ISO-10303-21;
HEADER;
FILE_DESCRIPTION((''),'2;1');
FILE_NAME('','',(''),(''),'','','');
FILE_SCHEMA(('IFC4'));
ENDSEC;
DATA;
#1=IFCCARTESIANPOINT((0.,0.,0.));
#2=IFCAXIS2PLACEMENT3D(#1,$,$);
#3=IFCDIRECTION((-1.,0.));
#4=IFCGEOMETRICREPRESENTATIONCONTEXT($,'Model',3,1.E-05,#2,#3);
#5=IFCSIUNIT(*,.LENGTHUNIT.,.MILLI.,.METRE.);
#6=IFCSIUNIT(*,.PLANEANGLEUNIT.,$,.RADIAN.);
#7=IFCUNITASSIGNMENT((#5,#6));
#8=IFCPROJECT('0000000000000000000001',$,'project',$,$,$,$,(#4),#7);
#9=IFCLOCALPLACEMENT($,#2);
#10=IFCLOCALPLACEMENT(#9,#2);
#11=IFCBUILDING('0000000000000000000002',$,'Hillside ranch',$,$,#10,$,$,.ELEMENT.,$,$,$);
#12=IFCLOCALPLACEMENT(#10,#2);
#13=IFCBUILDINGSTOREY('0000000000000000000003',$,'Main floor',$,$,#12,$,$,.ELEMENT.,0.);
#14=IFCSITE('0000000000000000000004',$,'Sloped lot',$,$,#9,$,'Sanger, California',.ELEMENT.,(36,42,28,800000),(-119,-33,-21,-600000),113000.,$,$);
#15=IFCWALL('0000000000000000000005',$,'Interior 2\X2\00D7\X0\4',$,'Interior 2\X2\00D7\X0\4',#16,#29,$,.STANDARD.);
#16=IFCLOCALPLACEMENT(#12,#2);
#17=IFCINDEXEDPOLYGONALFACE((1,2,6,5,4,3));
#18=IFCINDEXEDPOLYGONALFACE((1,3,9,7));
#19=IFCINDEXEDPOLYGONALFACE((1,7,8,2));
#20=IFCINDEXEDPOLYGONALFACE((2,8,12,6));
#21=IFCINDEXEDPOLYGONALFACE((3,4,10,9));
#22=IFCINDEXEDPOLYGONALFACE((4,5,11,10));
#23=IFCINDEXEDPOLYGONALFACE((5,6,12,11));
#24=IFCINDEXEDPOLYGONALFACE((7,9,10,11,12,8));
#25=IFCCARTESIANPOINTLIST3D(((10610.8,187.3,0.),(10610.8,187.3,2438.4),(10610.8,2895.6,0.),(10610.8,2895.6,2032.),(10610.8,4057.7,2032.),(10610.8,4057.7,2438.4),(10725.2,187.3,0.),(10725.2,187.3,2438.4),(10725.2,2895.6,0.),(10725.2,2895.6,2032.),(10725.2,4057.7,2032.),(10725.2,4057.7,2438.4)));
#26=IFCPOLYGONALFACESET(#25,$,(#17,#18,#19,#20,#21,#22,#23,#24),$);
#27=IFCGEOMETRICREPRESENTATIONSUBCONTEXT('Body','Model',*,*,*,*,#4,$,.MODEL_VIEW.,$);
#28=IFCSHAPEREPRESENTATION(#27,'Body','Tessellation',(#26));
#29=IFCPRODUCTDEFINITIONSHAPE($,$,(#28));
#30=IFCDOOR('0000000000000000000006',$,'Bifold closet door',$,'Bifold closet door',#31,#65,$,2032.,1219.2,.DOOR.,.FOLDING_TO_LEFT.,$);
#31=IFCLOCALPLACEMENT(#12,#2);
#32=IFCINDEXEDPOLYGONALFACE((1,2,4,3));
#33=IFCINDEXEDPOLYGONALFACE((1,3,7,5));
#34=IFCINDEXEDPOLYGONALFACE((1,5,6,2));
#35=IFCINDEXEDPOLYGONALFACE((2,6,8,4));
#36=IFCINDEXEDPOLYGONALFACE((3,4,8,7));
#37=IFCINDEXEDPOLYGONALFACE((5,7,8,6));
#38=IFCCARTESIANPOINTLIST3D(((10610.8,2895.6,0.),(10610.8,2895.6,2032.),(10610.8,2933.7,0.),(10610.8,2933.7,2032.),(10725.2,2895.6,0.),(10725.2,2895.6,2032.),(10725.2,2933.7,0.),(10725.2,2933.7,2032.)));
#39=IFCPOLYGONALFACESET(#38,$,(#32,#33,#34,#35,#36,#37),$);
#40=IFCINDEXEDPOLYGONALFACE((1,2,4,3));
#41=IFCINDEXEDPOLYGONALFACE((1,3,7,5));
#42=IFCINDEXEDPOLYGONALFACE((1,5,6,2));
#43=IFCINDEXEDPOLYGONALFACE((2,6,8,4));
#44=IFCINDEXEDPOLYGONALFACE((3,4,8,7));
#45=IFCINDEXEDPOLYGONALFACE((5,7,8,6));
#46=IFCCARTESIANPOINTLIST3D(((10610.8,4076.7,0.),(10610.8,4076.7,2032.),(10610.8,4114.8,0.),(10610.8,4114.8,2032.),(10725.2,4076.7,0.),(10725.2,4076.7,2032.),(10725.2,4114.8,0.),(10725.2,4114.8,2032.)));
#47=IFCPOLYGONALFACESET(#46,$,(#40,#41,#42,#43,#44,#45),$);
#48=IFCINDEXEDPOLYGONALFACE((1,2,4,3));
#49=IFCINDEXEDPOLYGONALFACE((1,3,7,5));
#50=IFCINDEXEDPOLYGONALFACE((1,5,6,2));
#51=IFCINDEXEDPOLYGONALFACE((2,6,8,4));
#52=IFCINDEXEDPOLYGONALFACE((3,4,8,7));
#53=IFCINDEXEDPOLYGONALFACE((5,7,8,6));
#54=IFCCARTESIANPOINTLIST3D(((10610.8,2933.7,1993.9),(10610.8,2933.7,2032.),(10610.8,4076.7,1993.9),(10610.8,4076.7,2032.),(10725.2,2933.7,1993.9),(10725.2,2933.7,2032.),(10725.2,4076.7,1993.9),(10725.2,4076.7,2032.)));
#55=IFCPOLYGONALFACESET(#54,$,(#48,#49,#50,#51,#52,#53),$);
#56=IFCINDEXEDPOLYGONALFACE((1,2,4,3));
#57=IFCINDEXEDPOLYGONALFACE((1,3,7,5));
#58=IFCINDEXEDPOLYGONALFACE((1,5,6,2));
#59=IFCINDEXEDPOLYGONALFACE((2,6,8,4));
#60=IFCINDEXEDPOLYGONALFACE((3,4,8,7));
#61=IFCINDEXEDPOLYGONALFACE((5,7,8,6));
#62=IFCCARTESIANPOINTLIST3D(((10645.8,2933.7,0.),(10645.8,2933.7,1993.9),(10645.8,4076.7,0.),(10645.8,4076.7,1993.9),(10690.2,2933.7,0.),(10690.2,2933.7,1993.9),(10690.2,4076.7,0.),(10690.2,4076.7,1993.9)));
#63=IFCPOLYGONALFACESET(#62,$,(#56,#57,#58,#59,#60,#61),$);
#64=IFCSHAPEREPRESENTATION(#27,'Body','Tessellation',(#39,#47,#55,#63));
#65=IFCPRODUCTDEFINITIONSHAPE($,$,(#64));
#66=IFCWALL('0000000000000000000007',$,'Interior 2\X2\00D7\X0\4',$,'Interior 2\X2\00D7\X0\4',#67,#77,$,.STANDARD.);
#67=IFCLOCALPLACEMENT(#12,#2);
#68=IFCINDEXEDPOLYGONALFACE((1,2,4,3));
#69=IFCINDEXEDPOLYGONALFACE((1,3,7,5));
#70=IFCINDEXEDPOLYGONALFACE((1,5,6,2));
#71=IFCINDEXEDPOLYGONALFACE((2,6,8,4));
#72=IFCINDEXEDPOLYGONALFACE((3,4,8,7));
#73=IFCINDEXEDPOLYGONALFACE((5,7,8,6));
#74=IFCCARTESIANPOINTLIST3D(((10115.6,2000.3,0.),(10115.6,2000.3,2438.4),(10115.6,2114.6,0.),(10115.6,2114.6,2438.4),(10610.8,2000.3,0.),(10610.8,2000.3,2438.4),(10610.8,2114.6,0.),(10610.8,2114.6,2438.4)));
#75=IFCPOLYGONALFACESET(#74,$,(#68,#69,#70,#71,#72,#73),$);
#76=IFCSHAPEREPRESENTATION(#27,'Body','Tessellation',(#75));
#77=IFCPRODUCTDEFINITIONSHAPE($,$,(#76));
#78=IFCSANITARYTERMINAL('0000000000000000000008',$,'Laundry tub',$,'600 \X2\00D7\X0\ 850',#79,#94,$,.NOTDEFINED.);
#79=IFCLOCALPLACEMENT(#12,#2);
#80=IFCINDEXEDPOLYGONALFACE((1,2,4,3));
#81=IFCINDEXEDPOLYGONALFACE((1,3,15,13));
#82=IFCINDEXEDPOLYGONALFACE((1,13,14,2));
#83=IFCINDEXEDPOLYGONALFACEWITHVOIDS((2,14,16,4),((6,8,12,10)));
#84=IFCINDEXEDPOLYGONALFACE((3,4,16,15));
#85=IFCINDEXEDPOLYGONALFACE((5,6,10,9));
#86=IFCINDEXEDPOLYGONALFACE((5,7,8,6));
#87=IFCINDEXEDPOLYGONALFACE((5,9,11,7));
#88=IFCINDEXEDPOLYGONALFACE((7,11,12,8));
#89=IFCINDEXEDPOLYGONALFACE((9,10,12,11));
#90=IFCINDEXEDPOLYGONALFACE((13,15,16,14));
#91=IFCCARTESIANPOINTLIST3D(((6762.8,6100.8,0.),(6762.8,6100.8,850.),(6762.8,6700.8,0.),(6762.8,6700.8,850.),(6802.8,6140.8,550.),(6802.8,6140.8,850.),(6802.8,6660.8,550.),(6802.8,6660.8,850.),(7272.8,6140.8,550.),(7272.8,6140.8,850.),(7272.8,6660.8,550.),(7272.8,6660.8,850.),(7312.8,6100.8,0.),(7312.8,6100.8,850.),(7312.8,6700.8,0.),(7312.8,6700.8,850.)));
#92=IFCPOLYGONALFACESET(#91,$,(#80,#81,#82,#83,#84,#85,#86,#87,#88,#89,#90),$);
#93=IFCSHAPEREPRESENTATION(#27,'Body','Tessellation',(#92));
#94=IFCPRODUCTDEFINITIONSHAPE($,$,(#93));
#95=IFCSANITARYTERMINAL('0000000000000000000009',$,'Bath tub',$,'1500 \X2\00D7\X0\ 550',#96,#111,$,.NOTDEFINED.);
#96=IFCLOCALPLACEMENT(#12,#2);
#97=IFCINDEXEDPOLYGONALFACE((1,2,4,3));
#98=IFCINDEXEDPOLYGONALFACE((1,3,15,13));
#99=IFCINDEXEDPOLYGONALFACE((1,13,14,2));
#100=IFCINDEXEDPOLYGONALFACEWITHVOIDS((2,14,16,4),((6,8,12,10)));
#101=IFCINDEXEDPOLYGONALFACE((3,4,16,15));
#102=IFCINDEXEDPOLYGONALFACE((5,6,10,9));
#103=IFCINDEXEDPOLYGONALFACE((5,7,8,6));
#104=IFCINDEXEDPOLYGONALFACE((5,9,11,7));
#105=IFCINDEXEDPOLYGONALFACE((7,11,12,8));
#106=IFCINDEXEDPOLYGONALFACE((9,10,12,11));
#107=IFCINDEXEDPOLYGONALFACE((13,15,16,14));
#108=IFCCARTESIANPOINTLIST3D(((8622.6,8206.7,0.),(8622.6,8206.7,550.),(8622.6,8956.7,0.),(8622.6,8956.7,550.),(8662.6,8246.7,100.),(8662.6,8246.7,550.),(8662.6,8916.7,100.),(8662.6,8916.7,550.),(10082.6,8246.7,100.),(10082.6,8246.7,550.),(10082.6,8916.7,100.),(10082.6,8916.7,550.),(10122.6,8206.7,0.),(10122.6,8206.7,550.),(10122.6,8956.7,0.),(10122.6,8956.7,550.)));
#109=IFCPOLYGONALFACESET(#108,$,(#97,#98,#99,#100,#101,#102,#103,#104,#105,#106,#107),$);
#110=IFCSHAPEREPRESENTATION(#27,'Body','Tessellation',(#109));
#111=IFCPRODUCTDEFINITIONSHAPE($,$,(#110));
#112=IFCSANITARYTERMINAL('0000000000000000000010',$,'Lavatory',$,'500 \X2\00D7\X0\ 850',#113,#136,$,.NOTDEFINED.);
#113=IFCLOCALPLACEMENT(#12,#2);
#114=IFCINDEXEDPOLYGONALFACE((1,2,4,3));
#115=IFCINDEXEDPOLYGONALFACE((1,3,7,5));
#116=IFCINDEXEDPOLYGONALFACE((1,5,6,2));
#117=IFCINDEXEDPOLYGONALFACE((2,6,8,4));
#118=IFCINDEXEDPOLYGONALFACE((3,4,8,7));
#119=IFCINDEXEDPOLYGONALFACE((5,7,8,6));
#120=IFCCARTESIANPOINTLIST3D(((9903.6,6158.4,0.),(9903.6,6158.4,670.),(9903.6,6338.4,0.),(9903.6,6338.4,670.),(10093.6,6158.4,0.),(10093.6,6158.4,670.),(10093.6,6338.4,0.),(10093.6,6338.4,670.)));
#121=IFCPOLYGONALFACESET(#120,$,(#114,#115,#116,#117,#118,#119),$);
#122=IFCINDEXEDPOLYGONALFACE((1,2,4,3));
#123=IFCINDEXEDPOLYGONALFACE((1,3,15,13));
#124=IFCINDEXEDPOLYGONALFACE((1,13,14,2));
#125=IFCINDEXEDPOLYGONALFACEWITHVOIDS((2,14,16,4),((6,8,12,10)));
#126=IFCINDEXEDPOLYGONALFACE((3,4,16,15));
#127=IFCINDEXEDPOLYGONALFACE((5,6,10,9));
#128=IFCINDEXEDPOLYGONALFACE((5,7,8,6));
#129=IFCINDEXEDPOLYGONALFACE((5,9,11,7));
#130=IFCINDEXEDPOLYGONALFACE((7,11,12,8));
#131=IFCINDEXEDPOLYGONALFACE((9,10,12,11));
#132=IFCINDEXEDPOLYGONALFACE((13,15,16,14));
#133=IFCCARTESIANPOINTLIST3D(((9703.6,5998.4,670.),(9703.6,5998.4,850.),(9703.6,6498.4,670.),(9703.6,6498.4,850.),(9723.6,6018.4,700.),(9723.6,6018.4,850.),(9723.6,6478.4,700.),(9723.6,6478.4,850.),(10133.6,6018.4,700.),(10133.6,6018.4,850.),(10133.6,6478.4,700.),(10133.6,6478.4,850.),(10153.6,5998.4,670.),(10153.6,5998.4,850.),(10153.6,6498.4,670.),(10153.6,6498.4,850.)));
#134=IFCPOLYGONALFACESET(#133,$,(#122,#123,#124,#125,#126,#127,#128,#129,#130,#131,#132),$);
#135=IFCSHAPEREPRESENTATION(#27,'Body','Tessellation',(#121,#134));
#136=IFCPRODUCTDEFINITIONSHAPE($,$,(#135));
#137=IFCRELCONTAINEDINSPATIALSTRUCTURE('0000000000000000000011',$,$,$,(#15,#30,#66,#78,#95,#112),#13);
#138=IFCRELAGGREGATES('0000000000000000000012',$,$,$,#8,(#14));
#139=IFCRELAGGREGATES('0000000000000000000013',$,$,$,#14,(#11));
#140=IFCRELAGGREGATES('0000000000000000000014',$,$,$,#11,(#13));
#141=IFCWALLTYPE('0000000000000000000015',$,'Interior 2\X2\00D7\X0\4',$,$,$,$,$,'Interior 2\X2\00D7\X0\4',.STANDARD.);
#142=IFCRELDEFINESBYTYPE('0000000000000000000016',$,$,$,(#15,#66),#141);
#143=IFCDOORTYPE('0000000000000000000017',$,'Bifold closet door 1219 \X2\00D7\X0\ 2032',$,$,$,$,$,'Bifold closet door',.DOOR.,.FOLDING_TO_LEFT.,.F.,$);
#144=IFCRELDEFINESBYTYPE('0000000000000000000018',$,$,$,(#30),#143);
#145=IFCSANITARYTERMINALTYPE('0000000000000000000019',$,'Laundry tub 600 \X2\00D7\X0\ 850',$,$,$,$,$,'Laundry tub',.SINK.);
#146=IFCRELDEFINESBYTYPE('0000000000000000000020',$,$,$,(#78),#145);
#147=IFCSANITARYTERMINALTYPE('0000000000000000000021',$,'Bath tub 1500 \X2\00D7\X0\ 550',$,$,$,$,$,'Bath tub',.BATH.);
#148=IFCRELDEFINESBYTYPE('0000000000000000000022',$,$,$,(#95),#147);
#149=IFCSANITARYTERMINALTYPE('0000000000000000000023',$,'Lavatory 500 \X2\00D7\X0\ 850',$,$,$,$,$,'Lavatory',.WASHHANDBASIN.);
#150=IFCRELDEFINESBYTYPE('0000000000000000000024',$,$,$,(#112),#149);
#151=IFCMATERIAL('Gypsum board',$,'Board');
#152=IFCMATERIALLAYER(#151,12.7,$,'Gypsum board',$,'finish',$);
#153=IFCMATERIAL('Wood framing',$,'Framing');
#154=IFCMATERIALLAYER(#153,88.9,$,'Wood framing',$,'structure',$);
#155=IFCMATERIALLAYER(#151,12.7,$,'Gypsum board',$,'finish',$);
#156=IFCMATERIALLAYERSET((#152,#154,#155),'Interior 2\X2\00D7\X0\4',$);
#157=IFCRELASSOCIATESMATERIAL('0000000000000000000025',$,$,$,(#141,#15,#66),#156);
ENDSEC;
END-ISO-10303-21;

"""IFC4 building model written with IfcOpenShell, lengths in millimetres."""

from ifc_helpers import new_model, entity, si_unit, direction, frame, origin, origin_with_axes, place, context, subcontext, project, spatial, polyline, outline, extrude, source, transform, mapped, material, layer, layer_set, layer_usage, type_object, type_shapes, element, fill, save


model = new_model("IFC4")

# Units and contexts
model_context = context("Model", 3, precision=1e-05, world=origin(), true_north=direction((-1.0, 0.0)))
body_context = subcontext(model_context, "Body", "Model", "MODEL_VIEW")
ifc_project = project(units=[si_unit("LENGTHUNIT", "METRE", prefix="MILLI"), si_unit("PLANEANGLEUNIT", "RADIAN")], contexts=[model_context])

# Site, building, storey
site_placement = place(None, origin())
site = spatial("IfcSite", under=ifc_project, at=site_placement, Name="Sloped lot", LongName="Sanger, California", CompositionType="ELEMENT", RefLatitude=(36, 42, 28, 800000), RefLongitude=(-119, -33, -21, -600000), RefElevation=113000.0)
building_placement = place(site_placement, origin())
building = spatial("IfcBuilding", under=site, at=building_placement, Name="Hillside ranch", CompositionType="ELEMENT")
storey_placement = place(building_placement, origin())
storey = spatial("IfcBuildingStorey", under=building, at=storey_placement, Name="Main floor", CompositionType="ELEMENT", Elevation=0.0)

# Shared definitions
ifc_material_1 = material(Name="Gypsum board", Category="Board")
ifc_layer_1 = layer(ifc_material_1, 12.7, Name="Gypsum board", Category="finish")
ifc_material_2 = material(Name="Wood framing", Category="Framing")
ifc_layer_2 = layer(ifc_material_2, 88.9, Name="Wood framing", Category="structure")
ifc_layer_3 = layer(ifc_material_1, 12.7, Name="Gypsum board", Category="finish")
ifc_layer_set = layer_set([ifc_layer_1, ifc_layer_2, ifc_layer_3], Name="Interior 2×4")
wall_type = type_object("IfcWallType", Name="Interior 2×4", ElementType="Interior 2×4", PredefinedType="STANDARD", material=ifc_layer_set)

# Wall, opening, door
door_type_1 = type_object("IfcDoorType", Name="Bifold closet door 1219 × 2032", ElementType="Bifold closet door", OperationType="FOLDING_TO_LEFT", ParameterTakesPrecedence=False, PredefinedType="DOOR")
ifc_layer_usage_1 = layer_usage(ifc_layer_set, "AXIS2", "NEGATIVE", 57.1)
wall_1_placement = place(storey_placement, frame((10668.0, 93.7, 0.0), z_axis=(0.0, 0.0, 1.0), x_axis=(0.0, 1.0, 0.0)))
wall_1 = element("IfcWall", 1, at=wall_1_placement, inside=storey, type_object=wall_type, material=ifc_layer_usage_1, Name="Interior 2×4", ObjectType="Interior 2×4", PredefinedType="STANDARD", context=body_context, shape_type="SweptSolid", body=[
    extrude(outline(polyline([(93.7, -57.1), (3964.0, -57.1), (3964.0, 57.1), (93.7, 57.1), (93.7, -57.1)])), origin(), (0.0, 0.0, 1.0), 2438.4),
])
opening_1_placement = place(wall_1_placement, frame((2801.9, 0.0, 0.0), z_axis=(0.0, 0.0, 1.0), x_axis=(1.0, 0.0, 0.0)))
opening_1 = element("IfcOpeningElement", 2, at=opening_1_placement, cuts=wall_1, PredefinedType="OPENING", context=body_context, shape_type="SweptSolid", body=[
    extrude(outline(polyline([(0.0, -67.2), (1219.2, -67.2), (1219.2, 67.2), (0.0, 67.2), (0.0, -67.2)])), origin(), (0.0, 0.0, 1.0), 2032.0),
])
door_1_placement = place(opening_1_placement, origin_with_axes())
door_1 = element("IfcDoor", 3, at=door_1_placement, inside=storey, type_object=door_type_1, Name="Bifold closet door", ObjectType="Bifold closet door", OperationType="FOLDING_TO_LEFT", OverallHeight=2032.0, OverallWidth=1219.2, PredefinedType="DOOR", context=body_context, shape_type="SweptSolid", body=[
    extrude(outline(polyline([(0.0, -57.1), (38.1, -57.1), (38.1, 57.1), (0.0, 57.1), (0.0, -57.1)])), origin(), (0.0, 0.0, 1.0), 2032.0),
    extrude(outline(polyline([(1181.1, -57.1), (1219.2, -57.1), (1219.2, 57.1), (1181.1, 57.1), (1181.1, -57.1)])), origin(), (0.0, 0.0, 1.0), 2032.0),
    extrude(outline(polyline([(38.1, -57.1), (1181.1, -57.1), (1181.1, 57.1), (38.1, 57.1), (38.1, -57.1)])), frame((0.0, 0.0, 1993.9)), (0.0, 0.0, 1.0), 38.1),
    extrude(outline(polyline([(38.1, -22.2), (1181.1, -22.2), (1181.1, 22.2), (38.1, 22.2), (38.1, -22.2)])), origin(), (0.0, 0.0, 1.0), 1993.9),
])
fill(opening_1, door_1)

# Wall
ifc_layer_usage_2 = layer_usage(ifc_layer_set, "AXIS2", "NEGATIVE", 57.1)
wall_2_placement = place(storey_placement, frame((10058.4, 2057.4, 0.0), z_axis=(0.0, 0.0, 1.0), x_axis=(1.0, 0.0, 0.0)))
element("IfcWall", 4, at=wall_2_placement, inside=storey, type_object=wall_type, material=ifc_layer_usage_2, Name="Interior 2×4", ObjectType="Interior 2×4", PredefinedType="STANDARD", context=body_context, shape_type="SweptSolid", body=[
    extrude(outline(polyline([(57.1, -57.1), (552.5, -57.1), (552.5, 57.1), (57.1, 57.1), (57.1, -57.1)])), origin(), (0.0, 0.0, 1.0), 2438.4),
])

# Sanitary terminals
sanitary_terminal_type_1 = type_object("IfcSanitaryTerminalType", Name="Laundry tub 600 × 850", ElementType="Laundry tub", PredefinedType="SINK")
cartesian_point_1 = entity("IfcCartesianPoint", [-300.0, 0.0])
cartesian_point_2 = entity("IfcCartesianPoint", [-260.0, 40.0])
shared_shape_1 = source(origin(), body_context, "Body", "SolidModel", [
    entity("IfcCsgSolid", entity("IfcBooleanResult", "DIFFERENCE", entity("IfcExtrudedAreaSolid", entity("IfcArbitraryClosedProfileDef", "AREA", None, entity("IfcPolyline", [cartesian_point_1, entity("IfcCartesianPoint", [300.0, 0.0]), entity("IfcCartesianPoint", [300.0, 550.0]), entity("IfcCartesianPoint", [-300.0, 550.0]), cartesian_point_1])), entity("IfcAxis2Placement3D", entity("IfcCartesianPoint", [0.0, 0.0, 0.0])), entity("IfcDirection", [0.0, 0.0, 1.0]), 850.0), entity("IfcExtrudedAreaSolid", entity("IfcArbitraryClosedProfileDef", "AREA", None, entity("IfcPolyline", [cartesian_point_2, entity("IfcCartesianPoint", [260.0, 40.0]), entity("IfcCartesianPoint", [260.0, 510.0]), entity("IfcCartesianPoint", [-260.0, 510.0]), cartesian_point_2])), entity("IfcAxis2Placement3D", entity("IfcCartesianPoint", [0.0, 0.0, 550.0])), entity("IfcDirection", [0.0, 0.0, 1.0]), 301.0))),
])
type_shapes(sanitary_terminal_type_1, [shared_shape_1])
sanitary_terminal_1_placement = place(storey_placement, frame((7312.8, 6400.8, 0.0), z_axis=(0.0, 0.0, 1.0), x_axis=(0.0, 1.0, 0.0)))
element("IfcSanitaryTerminal", 5, at=sanitary_terminal_1_placement, inside=storey, type_object=sanitary_terminal_type_1, Name="Laundry tub", ObjectType="600 × 850", PredefinedType="NOTDEFINED", context=body_context, shape_type="MappedRepresentation", body=[
    mapped(shared_shape_1, transform((0.0, 0.0, 0.0))),
])
sanitary_terminal_type_2 = type_object("IfcSanitaryTerminalType", Name="Bath tub 1500 × 550", ElementType="Bath tub", PredefinedType="BATH")
cartesian_point_3 = entity("IfcCartesianPoint", [-750.0, 0.0])
cartesian_point_4 = entity("IfcCartesianPoint", [-710.0, 40.0])
shared_shape_2 = source(origin(), body_context, "Body", "SolidModel", [
    entity("IfcCsgSolid", entity("IfcBooleanResult", "DIFFERENCE", entity("IfcExtrudedAreaSolid", entity("IfcArbitraryClosedProfileDef", "AREA", None, entity("IfcPolyline", [cartesian_point_3, entity("IfcCartesianPoint", [750.0, 0.0]), entity("IfcCartesianPoint", [750.0, 750.0]), entity("IfcCartesianPoint", [-750.0, 750.0]), cartesian_point_3])), entity("IfcAxis2Placement3D", entity("IfcCartesianPoint", [0.0, 0.0, 0.0])), entity("IfcDirection", [0.0, 0.0, 1.0]), 550.0), entity("IfcExtrudedAreaSolid", entity("IfcArbitraryClosedProfileDef", "AREA", None, entity("IfcPolyline", [cartesian_point_4, entity("IfcCartesianPoint", [710.0, 40.0]), entity("IfcCartesianPoint", [710.0, 710.0]), entity("IfcCartesianPoint", [-710.0, 710.0]), cartesian_point_4])), entity("IfcAxis2Placement3D", entity("IfcCartesianPoint", [0.0, 0.0, 100.0])), entity("IfcDirection", [0.0, 0.0, 1.0]), 451.0))),
])
type_shapes(sanitary_terminal_type_2, [shared_shape_2])
sanitary_terminal_2_placement = place(storey_placement, frame((9372.6, 8206.7, 0.0), z_axis=(0.0, 0.0, 1.0), x_axis=(1.0, 0.0, 0.0)))
element("IfcSanitaryTerminal", 6, at=sanitary_terminal_2_placement, inside=storey, type_object=sanitary_terminal_type_2, Name="Bath tub", ObjectType="1500 × 550", PredefinedType="NOTDEFINED", context=body_context, shape_type="MappedRepresentation", body=[
    mapped(shared_shape_2, transform((0.0, 0.0, 0.0))),
])
sanitary_terminal_type_3 = type_object("IfcSanitaryTerminalType", Name="Lavatory 500 × 850", ElementType="Lavatory", PredefinedType="WASHHANDBASIN")
cartesian_point_5 = entity("IfcCartesianPoint", [-250.0, 0.0])
cartesian_point_6 = entity("IfcCartesianPoint", [-230.0, 20.0])
shared_shape_3 = source(origin(), body_context, "Body", "SolidModel", [
    extrude(outline(polyline([(-90.0, 200.0), (90.0, 200.0), (90.0, 390.0), (-90.0, 390.0), (-90.0, 200.0)])), origin(), (0.0, 0.0, 1.0), 670.0),
    entity("IfcCsgSolid", entity("IfcBooleanResult", "DIFFERENCE", entity("IfcExtrudedAreaSolid", entity("IfcArbitraryClosedProfileDef", "AREA", None, entity("IfcPolyline", [cartesian_point_5, entity("IfcCartesianPoint", [250.0, 0.0]), entity("IfcCartesianPoint", [250.0, 450.0]), entity("IfcCartesianPoint", [-250.0, 450.0]), cartesian_point_5])), entity("IfcAxis2Placement3D", entity("IfcCartesianPoint", [0.0, 0.0, 670.0])), entity("IfcDirection", [0.0, 0.0, 1.0]), 180.0), entity("IfcExtrudedAreaSolid", entity("IfcArbitraryClosedProfileDef", "AREA", None, entity("IfcPolyline", [cartesian_point_6, entity("IfcCartesianPoint", [230.0, 20.0]), entity("IfcCartesianPoint", [230.0, 430.0]), entity("IfcCartesianPoint", [-230.0, 430.0]), cartesian_point_6])), entity("IfcAxis2Placement3D", entity("IfcCartesianPoint", [0.0, 0.0, 700.0])), entity("IfcDirection", [0.0, 0.0, 1.0]), 151.0))),
])
type_shapes(sanitary_terminal_type_3, [shared_shape_3])
sanitary_terminal_3_placement = place(storey_placement, frame((9703.6, 6248.4, 0.0), z_axis=(0.0, 0.0, 1.0), x_axis=(0.0, -1.0, 0.0)))
element("IfcSanitaryTerminal", 7, at=sanitary_terminal_3_placement, inside=storey, type_object=sanitary_terminal_type_3, Name="Lavatory", ObjectType="500 × 850", PredefinedType="NOTDEFINED", context=body_context, shape_type="MappedRepresentation", body=[
    mapped(shared_shape_3, transform((0.0, 0.0, 0.0))),
])

save(model, "model.ifc")
